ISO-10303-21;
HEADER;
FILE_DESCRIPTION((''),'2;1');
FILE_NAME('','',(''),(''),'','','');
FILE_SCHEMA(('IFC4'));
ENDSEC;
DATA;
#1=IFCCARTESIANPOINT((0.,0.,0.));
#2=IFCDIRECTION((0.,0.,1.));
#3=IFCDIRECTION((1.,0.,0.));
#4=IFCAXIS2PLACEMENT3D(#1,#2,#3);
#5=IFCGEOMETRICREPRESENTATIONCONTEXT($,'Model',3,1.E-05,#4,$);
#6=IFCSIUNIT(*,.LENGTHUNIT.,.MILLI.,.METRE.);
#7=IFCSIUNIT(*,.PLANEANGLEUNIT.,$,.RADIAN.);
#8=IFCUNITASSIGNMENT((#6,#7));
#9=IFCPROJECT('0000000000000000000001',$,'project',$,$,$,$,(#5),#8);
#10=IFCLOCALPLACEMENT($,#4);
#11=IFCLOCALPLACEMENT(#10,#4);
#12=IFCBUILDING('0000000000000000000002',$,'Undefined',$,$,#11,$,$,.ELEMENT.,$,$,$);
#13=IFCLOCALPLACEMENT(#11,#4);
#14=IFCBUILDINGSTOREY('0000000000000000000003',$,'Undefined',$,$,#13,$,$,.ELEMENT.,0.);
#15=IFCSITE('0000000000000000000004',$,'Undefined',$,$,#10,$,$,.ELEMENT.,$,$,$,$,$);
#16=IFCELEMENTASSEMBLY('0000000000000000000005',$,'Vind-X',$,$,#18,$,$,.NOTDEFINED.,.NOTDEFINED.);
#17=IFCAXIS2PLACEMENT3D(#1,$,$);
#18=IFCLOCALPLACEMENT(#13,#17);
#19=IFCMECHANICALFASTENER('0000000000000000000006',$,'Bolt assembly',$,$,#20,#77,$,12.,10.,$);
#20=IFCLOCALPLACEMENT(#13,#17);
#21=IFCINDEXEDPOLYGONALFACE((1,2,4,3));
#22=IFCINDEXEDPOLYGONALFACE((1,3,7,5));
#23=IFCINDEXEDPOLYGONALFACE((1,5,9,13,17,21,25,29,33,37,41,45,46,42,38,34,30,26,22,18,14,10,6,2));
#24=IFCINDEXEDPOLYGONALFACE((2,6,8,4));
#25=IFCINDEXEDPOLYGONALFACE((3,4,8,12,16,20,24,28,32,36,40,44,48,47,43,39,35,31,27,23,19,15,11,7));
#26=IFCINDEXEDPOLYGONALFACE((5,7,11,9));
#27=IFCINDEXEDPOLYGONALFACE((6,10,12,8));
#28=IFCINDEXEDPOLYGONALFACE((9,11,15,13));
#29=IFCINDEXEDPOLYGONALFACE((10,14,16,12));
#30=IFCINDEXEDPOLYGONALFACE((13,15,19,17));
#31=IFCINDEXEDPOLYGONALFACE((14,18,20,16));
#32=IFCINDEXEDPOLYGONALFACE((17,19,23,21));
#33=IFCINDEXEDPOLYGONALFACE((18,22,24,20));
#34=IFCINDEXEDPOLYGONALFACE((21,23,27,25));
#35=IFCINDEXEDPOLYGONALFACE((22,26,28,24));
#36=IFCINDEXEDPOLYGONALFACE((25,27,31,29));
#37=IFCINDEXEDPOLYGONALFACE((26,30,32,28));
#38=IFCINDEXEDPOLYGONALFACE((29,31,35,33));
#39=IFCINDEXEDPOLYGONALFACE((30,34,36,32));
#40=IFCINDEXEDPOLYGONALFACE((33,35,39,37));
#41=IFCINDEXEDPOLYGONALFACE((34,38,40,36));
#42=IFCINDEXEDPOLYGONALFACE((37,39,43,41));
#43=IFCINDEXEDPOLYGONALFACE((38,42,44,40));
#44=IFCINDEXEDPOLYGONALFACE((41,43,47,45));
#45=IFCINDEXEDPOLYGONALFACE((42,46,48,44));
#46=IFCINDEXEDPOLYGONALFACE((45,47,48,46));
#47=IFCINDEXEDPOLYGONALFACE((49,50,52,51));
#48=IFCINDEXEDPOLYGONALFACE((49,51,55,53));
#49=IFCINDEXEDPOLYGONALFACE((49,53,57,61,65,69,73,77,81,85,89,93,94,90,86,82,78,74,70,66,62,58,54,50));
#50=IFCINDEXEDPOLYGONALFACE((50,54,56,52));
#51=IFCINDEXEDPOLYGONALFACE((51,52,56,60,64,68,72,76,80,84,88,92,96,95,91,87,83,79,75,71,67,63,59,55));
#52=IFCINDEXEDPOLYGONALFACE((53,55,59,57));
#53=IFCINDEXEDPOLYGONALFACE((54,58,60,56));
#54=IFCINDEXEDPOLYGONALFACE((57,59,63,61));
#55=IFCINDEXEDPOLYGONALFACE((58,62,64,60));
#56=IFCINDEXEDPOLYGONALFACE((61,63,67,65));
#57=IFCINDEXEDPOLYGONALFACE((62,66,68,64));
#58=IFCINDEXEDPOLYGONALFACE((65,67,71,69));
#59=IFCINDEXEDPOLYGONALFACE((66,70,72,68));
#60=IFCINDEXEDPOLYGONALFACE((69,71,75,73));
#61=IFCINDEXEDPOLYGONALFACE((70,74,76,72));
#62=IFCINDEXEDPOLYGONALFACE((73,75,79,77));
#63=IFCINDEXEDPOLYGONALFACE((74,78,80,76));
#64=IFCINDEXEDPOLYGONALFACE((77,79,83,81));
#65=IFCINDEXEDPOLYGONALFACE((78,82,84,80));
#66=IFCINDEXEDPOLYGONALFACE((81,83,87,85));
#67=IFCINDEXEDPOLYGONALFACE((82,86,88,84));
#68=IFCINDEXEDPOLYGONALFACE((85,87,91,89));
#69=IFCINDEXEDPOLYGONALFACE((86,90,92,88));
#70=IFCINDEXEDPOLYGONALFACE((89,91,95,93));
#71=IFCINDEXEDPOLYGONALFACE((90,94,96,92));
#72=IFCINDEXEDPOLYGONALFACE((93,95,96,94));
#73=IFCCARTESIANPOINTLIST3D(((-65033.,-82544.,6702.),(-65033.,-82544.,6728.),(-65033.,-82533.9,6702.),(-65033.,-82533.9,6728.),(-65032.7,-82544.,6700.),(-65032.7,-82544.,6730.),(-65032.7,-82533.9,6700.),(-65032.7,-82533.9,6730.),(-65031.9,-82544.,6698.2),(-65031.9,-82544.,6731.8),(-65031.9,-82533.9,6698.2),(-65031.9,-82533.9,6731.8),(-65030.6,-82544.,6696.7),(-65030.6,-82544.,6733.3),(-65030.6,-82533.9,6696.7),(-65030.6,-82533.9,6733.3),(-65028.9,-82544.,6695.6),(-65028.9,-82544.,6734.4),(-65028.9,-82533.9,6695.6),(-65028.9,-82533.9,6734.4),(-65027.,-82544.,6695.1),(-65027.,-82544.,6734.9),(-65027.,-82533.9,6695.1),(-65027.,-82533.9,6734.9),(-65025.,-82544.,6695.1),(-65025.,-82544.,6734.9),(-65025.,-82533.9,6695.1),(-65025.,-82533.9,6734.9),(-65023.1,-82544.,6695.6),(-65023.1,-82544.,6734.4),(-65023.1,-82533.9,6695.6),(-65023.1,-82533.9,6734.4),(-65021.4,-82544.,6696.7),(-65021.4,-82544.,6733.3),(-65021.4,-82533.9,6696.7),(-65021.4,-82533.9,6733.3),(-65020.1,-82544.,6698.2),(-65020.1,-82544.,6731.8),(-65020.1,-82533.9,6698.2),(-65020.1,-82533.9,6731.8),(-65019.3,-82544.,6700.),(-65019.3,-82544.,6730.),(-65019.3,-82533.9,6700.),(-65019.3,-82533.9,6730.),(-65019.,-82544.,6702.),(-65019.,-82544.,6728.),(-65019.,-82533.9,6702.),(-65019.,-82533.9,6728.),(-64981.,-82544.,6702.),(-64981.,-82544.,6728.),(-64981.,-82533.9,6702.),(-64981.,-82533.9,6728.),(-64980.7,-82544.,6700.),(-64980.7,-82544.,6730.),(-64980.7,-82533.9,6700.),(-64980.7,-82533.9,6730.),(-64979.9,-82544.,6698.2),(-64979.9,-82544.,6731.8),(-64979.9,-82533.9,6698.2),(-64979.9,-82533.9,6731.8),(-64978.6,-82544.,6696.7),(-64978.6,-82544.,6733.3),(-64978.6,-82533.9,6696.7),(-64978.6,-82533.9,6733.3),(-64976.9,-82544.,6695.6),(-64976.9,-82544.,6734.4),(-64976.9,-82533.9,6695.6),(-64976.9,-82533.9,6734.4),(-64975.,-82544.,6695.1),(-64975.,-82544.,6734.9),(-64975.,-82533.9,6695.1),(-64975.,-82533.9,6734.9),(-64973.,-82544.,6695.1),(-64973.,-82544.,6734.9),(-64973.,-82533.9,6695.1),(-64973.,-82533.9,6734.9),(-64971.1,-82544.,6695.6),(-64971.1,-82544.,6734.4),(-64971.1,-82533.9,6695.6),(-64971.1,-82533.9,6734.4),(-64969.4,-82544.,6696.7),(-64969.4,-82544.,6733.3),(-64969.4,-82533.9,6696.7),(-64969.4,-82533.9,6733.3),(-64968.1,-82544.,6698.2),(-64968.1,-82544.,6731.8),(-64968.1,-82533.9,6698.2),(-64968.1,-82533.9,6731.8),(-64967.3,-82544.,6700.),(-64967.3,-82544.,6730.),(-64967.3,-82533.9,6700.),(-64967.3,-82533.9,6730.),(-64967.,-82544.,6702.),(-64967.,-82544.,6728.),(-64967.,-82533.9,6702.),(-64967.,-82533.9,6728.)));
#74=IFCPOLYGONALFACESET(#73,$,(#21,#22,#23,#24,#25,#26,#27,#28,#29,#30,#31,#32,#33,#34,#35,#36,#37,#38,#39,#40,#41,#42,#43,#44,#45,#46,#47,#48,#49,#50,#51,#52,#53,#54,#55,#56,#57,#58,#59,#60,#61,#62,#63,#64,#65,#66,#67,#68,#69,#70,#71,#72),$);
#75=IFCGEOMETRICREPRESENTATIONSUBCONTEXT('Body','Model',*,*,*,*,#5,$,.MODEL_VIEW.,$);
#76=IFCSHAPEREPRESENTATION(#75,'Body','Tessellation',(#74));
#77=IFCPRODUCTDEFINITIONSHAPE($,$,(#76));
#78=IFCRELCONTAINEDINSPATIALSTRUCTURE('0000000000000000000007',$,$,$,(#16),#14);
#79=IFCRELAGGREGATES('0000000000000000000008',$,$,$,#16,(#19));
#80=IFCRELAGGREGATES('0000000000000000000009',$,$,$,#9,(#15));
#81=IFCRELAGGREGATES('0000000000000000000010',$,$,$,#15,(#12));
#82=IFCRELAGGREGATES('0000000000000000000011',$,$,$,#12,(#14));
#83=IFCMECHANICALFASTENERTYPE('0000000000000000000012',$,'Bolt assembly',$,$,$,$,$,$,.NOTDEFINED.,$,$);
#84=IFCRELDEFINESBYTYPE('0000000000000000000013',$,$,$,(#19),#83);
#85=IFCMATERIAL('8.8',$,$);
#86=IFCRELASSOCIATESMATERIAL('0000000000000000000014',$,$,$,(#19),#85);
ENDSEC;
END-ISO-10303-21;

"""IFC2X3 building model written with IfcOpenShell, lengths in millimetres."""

from ifc_helpers import new_model, si_unit, frame, frame_2d, origin_with_axes, place, context, subcontext, project, spatial, polyline, circle_curve, parameter, trimmed, segment, composite_curve, outline, extrude, source, transform, mapped, material, type_object, element, aggregate, save


model = new_model("IFC2X3")

# Units and contexts
model_context = context("Model", 3, precision=1e-05, world=origin_with_axes())
body_context = subcontext(model_context, "Body", "Model", "MODEL_VIEW")
ifc_project = project(units=[si_unit("LENGTHUNIT", "METRE", prefix="MILLI"), si_unit("PLANEANGLEUNIT", "RADIAN")], contexts=[model_context])

# Site, building, storey
site_placement = place(None, origin_with_axes())
site = spatial("IfcSite", under=ifc_project, at=site_placement, Name="Undefined", CompositionType="ELEMENT")
building_placement = place(site_placement, origin_with_axes())
building = spatial("IfcBuilding", under=site, at=building_placement, Name="Undefined", CompositionType="ELEMENT")
storey_placement = place(building_placement, origin_with_axes())
storey = spatial("IfcBuildingStorey", under=building, at=storey_placement, Name="Undefined", CompositionType="ELEMENT", Elevation=0.0)

# Element assembly
assembly_1_placement = place(storey_placement, origin_with_axes())
assembly_1 = element("IfcElementAssembly", 1, at=assembly_1_placement, inside=storey, Name="Vind-X", AssemblyPlace="NOTDEFINED", PredefinedType="NOTDEFINED")

# Mechanical fastener
ifc_material_1 = material(Name="8.8")
mechanical_fastener_type = type_object("IfcMechanicalFastenerType", Name="Bolt assembly")
shared_shape_1 = source(origin_with_axes(), body_context, "Body", "SweptSolid", [
    extrude(outline(composite_curve([segment(polyline([(-13.0, 7.0), (13.0, 7.0)]), True, "CONTINUOUS"), segment(trimmed(circle_curve(frame_2d((13.0, 0.0), x_axis=(0.0, 1.0)), 7.0), [parameter(0.0)], [parameter(3.141593)], False, "PARAMETER"), True, "CONTINUOUS"), segment(polyline([(13.0, -7.0), (-13.0, -7.0)]), True, "CONTINUOUS"), segment(trimmed(circle_curve(frame_2d((-13.0, 0.0), x_axis=(0.0, -1.0)), 7.0), [parameter(0.0)], [parameter(3.141593)], False, "PARAMETER"), True, "DISCONTINUOUS")], self_intersect=False)), frame((0.0, -5.0, 0.0), z_axis=(0.0, 1.0, 0.0), x_axis=(1.0, 0.0, 0.0)), (0.0, 0.0, 1.0), 10.1),
])
mechanical_fastener_1_placement = place(assembly_1_placement, frame((-65000.0, -82538.9, 6715.0), z_axis=(-1.0, 0.0, 0.0), x_axis=(0.0, 0.0, -1.0)))
mechanical_fastener_1 = element("IfcMechanicalFastener", 2, at=mechanical_fastener_1_placement, type_object=mechanical_fastener_type, material=ifc_material_1, Name="Bolt assembly", NominalDiameter=12.0, NominalLength=10.0, context=body_context, shape_type="MappedRepresentation", body=[
    mapped(shared_shape_1, transform((0.0, 0.0, -26.0))),
    mapped(shared_shape_1, transform((0.0, 0.0, 26.0))),
])
aggregate(assembly_1, [mechanical_fastener_1])

save(model, "model.ifc")
